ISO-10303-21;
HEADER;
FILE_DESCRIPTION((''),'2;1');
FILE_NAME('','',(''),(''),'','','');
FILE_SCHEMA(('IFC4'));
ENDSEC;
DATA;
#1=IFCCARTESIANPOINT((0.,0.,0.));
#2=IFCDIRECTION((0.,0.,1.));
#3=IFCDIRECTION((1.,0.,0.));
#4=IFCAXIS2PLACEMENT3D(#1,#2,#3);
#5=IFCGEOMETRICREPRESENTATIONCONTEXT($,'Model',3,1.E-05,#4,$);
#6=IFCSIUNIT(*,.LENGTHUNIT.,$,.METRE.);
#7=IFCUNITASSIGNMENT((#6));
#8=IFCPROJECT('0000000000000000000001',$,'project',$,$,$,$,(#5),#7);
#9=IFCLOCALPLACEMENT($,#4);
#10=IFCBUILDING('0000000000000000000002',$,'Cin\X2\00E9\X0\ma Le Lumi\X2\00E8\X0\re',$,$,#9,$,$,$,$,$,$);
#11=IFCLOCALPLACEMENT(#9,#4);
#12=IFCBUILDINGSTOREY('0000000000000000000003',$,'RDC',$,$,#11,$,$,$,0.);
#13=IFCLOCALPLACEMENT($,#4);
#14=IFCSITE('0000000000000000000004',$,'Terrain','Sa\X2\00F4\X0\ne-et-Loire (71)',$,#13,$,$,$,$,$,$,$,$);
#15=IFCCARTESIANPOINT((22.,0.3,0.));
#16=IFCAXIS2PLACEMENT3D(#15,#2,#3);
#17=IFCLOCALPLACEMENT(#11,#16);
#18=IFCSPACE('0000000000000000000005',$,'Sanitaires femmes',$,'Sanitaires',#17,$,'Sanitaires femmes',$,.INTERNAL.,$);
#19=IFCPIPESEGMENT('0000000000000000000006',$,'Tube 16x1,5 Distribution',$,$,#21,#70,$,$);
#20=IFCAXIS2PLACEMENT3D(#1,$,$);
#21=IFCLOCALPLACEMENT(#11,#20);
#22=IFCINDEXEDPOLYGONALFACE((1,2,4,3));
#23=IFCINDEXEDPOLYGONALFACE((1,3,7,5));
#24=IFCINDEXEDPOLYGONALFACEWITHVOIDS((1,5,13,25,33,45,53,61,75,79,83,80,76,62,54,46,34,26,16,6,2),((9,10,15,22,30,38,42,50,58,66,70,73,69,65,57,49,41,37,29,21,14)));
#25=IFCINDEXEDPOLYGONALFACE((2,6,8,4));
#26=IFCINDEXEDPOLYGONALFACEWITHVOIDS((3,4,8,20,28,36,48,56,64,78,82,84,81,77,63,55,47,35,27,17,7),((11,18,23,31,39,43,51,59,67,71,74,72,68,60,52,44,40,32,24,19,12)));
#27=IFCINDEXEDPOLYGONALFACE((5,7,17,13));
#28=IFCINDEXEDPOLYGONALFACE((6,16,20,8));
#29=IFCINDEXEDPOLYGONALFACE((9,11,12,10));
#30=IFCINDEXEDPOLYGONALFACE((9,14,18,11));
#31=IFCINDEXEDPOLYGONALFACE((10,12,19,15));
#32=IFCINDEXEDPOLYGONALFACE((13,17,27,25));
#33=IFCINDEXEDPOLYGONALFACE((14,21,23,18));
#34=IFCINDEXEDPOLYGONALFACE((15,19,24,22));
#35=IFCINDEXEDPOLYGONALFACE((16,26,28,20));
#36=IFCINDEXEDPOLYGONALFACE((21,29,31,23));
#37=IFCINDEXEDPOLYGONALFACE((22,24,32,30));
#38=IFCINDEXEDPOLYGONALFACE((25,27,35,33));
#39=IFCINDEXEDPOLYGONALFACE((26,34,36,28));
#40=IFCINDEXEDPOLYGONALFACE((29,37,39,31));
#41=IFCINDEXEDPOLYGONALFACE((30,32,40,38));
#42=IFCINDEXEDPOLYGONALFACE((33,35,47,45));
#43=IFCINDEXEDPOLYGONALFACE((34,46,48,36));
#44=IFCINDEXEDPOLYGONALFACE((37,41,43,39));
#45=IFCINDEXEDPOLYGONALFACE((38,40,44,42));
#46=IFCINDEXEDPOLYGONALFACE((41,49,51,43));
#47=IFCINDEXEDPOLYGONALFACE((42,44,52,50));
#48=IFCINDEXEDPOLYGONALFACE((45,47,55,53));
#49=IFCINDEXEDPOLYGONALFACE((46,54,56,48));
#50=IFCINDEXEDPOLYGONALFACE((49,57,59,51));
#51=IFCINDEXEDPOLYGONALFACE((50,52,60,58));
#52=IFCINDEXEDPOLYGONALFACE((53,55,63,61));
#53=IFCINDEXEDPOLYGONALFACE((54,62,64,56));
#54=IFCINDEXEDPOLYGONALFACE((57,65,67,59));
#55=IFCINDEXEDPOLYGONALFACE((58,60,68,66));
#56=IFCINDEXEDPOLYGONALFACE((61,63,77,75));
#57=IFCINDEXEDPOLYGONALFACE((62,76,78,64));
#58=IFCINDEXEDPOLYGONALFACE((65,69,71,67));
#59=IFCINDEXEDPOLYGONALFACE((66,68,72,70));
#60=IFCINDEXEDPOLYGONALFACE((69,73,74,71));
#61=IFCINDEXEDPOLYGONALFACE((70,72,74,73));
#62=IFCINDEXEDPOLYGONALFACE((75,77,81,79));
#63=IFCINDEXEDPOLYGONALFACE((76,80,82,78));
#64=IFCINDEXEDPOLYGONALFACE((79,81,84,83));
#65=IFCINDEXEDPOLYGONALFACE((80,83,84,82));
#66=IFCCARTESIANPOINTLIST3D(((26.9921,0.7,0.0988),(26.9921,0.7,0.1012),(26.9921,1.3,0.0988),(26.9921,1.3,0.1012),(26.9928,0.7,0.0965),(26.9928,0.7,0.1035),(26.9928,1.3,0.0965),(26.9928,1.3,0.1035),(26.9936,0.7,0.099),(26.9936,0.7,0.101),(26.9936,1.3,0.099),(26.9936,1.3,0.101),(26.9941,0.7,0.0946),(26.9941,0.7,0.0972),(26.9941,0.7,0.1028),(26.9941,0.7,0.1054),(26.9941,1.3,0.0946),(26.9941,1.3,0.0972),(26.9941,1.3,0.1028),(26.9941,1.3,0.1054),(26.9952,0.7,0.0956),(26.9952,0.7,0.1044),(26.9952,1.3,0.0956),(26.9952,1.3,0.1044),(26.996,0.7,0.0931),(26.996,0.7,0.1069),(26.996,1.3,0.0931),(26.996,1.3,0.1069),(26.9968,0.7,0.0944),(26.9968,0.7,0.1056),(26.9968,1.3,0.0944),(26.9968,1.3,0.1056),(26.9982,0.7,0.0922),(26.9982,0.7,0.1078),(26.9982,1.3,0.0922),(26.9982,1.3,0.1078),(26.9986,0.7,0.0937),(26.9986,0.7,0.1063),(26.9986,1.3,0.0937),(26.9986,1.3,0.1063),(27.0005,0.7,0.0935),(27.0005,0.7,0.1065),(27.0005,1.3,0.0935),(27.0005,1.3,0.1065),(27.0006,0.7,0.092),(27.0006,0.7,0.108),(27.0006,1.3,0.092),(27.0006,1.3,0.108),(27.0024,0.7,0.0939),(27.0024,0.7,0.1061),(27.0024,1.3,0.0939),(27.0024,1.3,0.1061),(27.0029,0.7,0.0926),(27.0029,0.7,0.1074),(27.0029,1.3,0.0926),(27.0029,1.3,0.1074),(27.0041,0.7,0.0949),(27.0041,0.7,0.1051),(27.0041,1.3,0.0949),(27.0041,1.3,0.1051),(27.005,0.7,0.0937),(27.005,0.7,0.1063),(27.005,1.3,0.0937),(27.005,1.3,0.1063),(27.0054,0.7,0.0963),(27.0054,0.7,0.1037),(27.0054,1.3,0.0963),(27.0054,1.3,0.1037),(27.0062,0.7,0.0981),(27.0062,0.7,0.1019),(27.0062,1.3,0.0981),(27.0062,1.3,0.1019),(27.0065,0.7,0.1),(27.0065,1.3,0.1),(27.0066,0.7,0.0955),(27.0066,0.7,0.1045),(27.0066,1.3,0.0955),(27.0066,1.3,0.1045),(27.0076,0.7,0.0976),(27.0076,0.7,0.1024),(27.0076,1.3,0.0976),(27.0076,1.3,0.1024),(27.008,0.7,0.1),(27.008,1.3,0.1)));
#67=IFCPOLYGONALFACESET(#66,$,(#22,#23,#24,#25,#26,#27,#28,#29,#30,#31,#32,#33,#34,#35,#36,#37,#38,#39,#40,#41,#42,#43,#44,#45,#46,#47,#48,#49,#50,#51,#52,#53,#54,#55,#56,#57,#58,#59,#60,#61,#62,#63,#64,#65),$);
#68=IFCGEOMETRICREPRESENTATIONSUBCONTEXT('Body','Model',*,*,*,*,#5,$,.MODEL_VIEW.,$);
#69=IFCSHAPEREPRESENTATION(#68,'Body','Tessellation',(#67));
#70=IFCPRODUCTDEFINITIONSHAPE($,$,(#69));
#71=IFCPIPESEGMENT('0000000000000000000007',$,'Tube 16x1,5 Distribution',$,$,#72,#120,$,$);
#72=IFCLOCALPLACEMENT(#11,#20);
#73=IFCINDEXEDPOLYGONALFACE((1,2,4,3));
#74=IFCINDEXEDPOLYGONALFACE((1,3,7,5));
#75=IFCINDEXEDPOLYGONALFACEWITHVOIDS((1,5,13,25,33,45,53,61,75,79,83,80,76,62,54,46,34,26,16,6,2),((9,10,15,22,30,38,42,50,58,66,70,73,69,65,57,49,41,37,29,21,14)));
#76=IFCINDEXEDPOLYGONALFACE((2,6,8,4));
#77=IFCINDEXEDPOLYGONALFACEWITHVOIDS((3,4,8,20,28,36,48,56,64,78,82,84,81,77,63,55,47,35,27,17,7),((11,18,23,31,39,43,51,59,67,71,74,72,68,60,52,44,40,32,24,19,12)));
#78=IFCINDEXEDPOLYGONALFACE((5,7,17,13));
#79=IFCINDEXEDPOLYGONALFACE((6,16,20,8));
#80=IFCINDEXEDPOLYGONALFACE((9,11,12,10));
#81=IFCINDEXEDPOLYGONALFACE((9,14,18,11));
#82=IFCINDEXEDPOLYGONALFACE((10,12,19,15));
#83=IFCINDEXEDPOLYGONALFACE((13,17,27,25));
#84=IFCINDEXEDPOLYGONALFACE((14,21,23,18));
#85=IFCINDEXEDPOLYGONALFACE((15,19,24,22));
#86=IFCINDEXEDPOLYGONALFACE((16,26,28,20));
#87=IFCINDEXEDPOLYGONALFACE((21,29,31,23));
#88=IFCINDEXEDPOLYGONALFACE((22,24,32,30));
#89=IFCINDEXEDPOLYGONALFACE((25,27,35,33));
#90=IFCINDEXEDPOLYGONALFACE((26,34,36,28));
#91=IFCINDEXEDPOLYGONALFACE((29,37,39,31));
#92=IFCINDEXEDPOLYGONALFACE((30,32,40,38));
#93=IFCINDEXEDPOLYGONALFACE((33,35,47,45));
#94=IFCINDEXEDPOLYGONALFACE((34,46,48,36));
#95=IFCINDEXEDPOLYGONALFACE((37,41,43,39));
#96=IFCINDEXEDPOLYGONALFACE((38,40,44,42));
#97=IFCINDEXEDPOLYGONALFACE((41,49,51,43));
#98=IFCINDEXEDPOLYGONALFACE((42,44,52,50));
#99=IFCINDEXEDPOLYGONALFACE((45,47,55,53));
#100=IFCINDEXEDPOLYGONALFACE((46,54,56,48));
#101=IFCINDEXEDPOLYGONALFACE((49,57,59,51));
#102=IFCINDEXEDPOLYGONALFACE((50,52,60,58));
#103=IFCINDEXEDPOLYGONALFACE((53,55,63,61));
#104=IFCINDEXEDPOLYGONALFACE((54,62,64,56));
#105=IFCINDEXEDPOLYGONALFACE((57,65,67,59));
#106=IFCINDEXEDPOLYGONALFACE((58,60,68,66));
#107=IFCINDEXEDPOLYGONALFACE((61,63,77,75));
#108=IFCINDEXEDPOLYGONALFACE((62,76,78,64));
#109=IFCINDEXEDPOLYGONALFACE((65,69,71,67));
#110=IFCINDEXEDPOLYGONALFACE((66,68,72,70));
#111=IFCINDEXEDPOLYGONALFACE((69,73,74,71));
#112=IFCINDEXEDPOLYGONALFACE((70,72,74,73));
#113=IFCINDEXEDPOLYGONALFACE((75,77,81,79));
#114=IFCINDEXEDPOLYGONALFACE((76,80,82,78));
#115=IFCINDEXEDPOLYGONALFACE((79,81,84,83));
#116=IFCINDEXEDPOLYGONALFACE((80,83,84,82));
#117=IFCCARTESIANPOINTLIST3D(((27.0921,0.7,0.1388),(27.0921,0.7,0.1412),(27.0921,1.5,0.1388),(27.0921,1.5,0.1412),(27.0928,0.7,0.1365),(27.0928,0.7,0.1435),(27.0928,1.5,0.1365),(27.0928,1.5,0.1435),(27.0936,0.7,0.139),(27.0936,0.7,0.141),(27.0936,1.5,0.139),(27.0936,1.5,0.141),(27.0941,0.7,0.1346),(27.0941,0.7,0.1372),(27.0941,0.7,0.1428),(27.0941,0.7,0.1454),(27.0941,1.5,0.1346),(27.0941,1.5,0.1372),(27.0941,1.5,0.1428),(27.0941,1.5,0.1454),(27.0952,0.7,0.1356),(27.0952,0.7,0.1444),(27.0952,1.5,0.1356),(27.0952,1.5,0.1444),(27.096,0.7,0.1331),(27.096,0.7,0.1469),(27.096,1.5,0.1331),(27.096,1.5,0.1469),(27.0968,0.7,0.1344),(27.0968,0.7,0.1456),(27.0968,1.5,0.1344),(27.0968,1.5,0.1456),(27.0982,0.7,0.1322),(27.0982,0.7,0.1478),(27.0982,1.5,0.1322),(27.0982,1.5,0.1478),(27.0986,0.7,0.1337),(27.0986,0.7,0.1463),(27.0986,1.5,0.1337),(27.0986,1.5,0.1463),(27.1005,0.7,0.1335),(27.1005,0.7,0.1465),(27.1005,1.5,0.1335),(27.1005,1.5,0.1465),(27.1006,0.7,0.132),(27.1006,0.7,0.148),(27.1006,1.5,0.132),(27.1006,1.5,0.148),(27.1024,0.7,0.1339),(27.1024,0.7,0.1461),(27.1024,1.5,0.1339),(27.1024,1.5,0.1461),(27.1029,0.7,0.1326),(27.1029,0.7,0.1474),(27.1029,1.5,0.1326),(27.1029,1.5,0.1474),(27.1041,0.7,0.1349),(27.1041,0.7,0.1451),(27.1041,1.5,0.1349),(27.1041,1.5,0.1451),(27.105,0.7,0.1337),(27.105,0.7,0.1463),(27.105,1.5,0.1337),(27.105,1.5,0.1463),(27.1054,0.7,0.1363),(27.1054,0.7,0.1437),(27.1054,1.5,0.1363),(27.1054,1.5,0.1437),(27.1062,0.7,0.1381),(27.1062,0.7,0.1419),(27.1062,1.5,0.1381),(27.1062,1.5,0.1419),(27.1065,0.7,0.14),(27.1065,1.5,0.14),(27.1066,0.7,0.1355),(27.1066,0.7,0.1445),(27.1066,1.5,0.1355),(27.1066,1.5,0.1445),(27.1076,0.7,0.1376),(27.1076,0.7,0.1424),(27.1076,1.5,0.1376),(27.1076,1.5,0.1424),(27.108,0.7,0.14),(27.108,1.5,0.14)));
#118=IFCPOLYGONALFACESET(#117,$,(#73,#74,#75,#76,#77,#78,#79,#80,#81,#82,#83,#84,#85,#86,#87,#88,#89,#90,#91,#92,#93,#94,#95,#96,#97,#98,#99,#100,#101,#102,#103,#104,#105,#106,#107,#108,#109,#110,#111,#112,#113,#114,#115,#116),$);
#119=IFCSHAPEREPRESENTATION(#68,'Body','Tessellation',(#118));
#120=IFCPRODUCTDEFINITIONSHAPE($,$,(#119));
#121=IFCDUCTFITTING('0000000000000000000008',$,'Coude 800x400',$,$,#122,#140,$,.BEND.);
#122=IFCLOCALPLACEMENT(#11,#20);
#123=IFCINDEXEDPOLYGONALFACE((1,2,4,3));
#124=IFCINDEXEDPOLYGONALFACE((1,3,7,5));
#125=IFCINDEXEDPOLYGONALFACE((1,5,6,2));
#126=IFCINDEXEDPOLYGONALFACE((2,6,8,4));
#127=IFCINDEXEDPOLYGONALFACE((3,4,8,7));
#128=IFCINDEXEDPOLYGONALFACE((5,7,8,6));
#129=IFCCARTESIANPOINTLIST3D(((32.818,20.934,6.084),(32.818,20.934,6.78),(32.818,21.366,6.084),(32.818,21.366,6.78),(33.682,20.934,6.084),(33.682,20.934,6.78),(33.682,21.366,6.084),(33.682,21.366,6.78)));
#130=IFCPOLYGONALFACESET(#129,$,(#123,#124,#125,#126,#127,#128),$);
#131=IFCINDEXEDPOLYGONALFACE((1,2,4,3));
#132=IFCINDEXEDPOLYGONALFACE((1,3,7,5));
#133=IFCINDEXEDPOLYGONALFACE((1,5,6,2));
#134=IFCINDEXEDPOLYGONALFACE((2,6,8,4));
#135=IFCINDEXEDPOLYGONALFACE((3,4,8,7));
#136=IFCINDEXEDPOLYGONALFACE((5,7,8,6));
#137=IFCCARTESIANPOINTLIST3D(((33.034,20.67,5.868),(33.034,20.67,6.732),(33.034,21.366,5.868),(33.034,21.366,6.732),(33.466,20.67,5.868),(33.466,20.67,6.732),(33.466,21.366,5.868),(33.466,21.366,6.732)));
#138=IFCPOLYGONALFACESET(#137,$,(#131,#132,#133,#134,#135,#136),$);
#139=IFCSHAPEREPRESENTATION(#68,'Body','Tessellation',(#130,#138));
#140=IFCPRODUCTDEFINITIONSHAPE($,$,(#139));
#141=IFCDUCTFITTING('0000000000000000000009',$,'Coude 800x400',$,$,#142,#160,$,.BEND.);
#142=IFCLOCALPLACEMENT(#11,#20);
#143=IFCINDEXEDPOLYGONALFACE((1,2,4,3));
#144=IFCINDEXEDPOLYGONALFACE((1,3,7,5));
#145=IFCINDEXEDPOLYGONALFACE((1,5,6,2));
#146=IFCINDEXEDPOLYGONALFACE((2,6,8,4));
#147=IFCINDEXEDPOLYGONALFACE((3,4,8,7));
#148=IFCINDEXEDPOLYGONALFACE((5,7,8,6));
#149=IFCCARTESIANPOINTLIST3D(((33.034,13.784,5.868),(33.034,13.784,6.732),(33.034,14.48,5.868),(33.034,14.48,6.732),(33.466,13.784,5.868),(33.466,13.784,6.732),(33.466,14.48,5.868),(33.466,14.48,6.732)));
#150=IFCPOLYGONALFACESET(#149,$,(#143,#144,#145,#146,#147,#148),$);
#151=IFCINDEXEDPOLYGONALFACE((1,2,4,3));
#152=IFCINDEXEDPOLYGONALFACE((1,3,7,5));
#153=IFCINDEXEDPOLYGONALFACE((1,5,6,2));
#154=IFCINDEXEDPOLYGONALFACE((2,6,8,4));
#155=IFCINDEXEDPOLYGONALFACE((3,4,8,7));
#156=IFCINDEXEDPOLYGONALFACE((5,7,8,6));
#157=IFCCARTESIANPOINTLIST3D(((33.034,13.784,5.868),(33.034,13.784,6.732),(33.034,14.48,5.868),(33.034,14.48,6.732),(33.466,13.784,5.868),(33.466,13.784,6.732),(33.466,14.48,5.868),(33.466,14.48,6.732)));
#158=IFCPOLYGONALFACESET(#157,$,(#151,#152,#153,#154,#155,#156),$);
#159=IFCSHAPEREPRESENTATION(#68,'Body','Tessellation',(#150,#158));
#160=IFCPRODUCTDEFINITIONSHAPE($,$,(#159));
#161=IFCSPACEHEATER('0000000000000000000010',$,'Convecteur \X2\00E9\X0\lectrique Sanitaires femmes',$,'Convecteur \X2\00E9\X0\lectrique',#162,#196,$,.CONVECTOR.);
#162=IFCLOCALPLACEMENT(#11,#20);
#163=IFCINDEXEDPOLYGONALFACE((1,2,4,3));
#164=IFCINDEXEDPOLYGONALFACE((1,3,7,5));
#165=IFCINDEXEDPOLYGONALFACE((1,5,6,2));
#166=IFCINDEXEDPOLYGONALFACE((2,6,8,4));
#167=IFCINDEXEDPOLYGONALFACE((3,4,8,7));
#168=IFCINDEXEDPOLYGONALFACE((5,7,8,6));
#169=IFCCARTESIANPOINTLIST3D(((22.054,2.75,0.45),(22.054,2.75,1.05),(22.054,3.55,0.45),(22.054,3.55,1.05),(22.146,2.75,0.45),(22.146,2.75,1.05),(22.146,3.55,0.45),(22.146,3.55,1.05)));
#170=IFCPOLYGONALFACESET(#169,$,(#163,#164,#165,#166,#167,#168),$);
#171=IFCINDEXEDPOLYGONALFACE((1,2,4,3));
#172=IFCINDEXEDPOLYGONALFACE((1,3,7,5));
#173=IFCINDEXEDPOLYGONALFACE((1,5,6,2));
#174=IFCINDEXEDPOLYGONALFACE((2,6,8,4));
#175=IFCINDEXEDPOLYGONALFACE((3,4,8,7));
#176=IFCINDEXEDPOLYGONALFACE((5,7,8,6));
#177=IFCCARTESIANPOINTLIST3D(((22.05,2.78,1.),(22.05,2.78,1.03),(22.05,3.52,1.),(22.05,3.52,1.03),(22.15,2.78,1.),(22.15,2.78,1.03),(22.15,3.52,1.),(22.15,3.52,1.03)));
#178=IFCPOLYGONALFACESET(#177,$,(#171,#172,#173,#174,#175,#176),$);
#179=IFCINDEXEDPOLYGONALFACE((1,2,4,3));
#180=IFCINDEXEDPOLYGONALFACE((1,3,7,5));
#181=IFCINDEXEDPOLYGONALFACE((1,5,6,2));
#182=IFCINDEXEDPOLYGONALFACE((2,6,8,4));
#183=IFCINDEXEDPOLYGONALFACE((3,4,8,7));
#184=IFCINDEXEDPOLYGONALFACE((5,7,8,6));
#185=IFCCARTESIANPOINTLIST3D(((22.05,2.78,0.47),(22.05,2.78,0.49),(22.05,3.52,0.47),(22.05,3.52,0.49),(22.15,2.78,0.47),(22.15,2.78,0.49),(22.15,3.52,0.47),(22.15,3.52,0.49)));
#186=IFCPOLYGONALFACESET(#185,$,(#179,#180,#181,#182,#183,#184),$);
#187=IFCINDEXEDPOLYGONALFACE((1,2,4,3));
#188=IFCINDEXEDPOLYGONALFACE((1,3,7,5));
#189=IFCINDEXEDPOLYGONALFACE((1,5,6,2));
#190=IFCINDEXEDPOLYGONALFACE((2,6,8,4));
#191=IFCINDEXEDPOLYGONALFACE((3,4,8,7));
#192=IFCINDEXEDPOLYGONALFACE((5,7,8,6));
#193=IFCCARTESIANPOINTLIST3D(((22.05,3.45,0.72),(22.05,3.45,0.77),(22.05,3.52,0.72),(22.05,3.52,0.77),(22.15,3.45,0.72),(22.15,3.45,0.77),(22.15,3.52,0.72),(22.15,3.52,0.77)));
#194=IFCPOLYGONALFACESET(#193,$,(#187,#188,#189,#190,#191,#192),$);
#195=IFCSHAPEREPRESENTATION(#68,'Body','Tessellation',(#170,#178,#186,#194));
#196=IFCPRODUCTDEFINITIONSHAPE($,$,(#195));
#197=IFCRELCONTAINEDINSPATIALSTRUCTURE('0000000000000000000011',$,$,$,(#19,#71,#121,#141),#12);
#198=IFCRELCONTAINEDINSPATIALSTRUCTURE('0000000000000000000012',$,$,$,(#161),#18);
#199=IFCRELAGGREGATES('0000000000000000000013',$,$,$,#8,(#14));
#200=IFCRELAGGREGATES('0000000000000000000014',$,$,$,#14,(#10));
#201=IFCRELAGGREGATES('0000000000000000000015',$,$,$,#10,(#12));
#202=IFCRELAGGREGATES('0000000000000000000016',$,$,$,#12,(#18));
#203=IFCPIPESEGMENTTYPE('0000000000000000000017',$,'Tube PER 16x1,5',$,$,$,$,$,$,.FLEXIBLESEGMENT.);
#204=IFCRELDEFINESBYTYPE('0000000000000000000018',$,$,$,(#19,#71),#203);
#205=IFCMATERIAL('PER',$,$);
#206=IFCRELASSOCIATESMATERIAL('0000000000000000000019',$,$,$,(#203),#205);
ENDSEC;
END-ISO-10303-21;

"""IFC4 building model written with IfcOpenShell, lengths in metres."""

from ifc_helpers import new_model, si_unit, frame, frame_2d, origin_with_axes, origin_2d, place, context, subcontext, project, spatial, rectangle, hollow_circle, extrude, material, type_object, element, save


model = new_model("IFC4")

# Units and contexts
model_context = context("Model", 3, precision=1e-05, world=origin_with_axes())
body_context = subcontext(model_context, "Body", "Model", "MODEL_VIEW")
ifc_project = project(units=[si_unit("LENGTHUNIT", "METRE")], contexts=[model_context])

# Site, building, storey
site_placement = place(None, origin_with_axes())
site = spatial("IfcSite", under=ifc_project, at=site_placement, Name="Terrain", Description="Saône-et-Loire (71)")
building_placement = place(None, origin_with_axes())
building = spatial("IfcBuilding", under=site, at=building_placement, Name="Cinéma Le Lumière")
storey_placement = place(building_placement, origin_with_axes())
storey = spatial("IfcBuildingStorey", under=building, at=storey_placement, Name="RDC", Elevation=0.0)

# Pipe segments
ifc_material_1 = material(Name="PER")
pipe_segment_type = type_object("IfcPipeSegmentType", Name="Tube PER 16x1,5", PredefinedType="FLEXIBLESEGMENT", material=ifc_material_1)
pipe_segment_1_placement = place(storey_placement, frame((27.0, 1.3, 0.1), z_axis=(0.0, -1.0, 0.0), x_axis=(1.0, 0.0, 0.0)))
element("IfcPipeSegment", 1, at=pipe_segment_1_placement, inside=storey, type_object=pipe_segment_type, Name="Tube 16x1,5 Distribution", context=body_context, shape_type="SweptSolid", body=[
    extrude(hollow_circle(Radius=0.008, WallThickness=0.0015), origin_with_axes(), (0.0, 0.0, 1.0), 0.6),
])
pipe_segment_2_placement = place(storey_placement, frame((27.1, 1.5, 0.14), z_axis=(0.0, -1.0, 0.0), x_axis=(1.0, 0.0, 0.0)))
element("IfcPipeSegment", 2, at=pipe_segment_2_placement, inside=storey, type_object=pipe_segment_type, Name="Tube 16x1,5 Distribution", context=body_context, shape_type="SweptSolid", body=[
    extrude(hollow_circle(Radius=0.008, WallThickness=0.0015), origin_with_axes(), (0.0, 0.0, 1.0), 0.8),
])

# Duct fittings
duct_fitting_1_placement = place(storey_placement, frame((33.25, 21.15, 6.3), z_axis=(0.0, 0.0, 1.0), x_axis=(1.0, 0.0, 0.0)))
element("IfcDuctFitting", 3, at=duct_fitting_1_placement, inside=storey, Name="Coude 800x400", PredefinedType="BEND", context=body_context, shape_type="SweptSolid", body=[
    extrude(rectangle(XDim=0.864, YDim=0.432, at=origin_2d()), frame((0.0, 0.0, -0.216), z_axis=(0.0, 0.0, 1.0), x_axis=(1.0, 0.0, 0.0)), (0.0, 0.0, 1.0), 0.696),
    extrude(rectangle(XDim=0.864, YDim=0.432, at=origin_2d()), frame((0.0, 0.216, 0.0), z_axis=(0.0, -1.0, 0.0), x_axis=(0.0, 0.0, 1.0)), (0.0, 0.0, 1.0), 0.696),
])
duct_fitting_2_placement = place(storey_placement, frame((33.25, 14.0, 6.3), z_axis=(0.0, 0.0, 1.0), x_axis=(1.0, 0.0, 0.0)))
element("IfcDuctFitting", 4, at=duct_fitting_2_placement, inside=storey, Name="Coude 800x400", PredefinedType="BEND", context=body_context, shape_type="SweptSolid", body=[
    extrude(rectangle(XDim=0.864, YDim=0.432, at=origin_2d()), frame((0.0, -0.216, 0.0), z_axis=(0.0, 1.0, 0.0), x_axis=(0.0, 0.0, 1.0)), (0.0, 0.0, 1.0), 0.696),
    extrude(rectangle(XDim=0.864, YDim=0.432, at=origin_2d()), frame((0.0, -0.216, 0.0), z_axis=(0.0, 1.0, 0.0), x_axis=(0.0, 0.0, 1.0)), (0.0, 0.0, 1.0), 0.696),
])

# Shared definitions
space_1_placement = place(storey_placement, frame((22.0, 0.3, 0.0), z_axis=(0.0, 0.0, 1.0), x_axis=(1.0, 0.0, 0.0)))
space_1 = spatial("IfcSpace", under=storey, at=space_1_placement, Name="Sanitaires femmes", ObjectType="Sanitaires", LongName="Sanitaires femmes", PredefinedType="INTERNAL")

# Space heater
space_heater_placement = place(space_1_placement, frame((0.05, 2.45, 0.45), z_axis=(0.0, 0.0, 1.0), x_axis=(1.0, 0.0, 0.0)))
element("IfcSpaceHeater", 5, at=space_heater_placement, inside=space_1, Name="Convecteur électrique Sanitaires femmes", ObjectType="Convecteur électrique", PredefinedType="CONVECTOR", context=body_context, shape_type="SweptSolid", body=[
    extrude(rectangle(XDim=0.092, YDim=0.8, at=frame_2d((0.046, 0.4))), frame((0.004, 0.0, 0.0), z_axis=(0.0, 0.0, 1.0), x_axis=(1.0, 0.0, 0.0)), (0.0, 0.0, 1.0), 0.6),
    extrude(rectangle(XDim=0.1, YDim=0.74, at=frame_2d((0.05, 0.37))), frame((0.0, 0.03, 0.55), z_axis=(0.0, 0.0, 1.0), x_axis=(1.0, 0.0, 0.0)), (0.0, 0.0, 1.0), 0.03),
    extrude(rectangle(XDim=0.1, YDim=0.74, at=frame_2d((0.05, 0.37))), frame((0.0, 0.03, 0.02), z_axis=(0.0, 0.0, 1.0), x_axis=(1.0, 0.0, 0.0)), (0.0, 0.0, 1.0), 0.02),
    extrude(rectangle(XDim=0.1, YDim=0.07, at=frame_2d((0.05, 0.035))), frame((0.0, 0.7, 0.27), z_axis=(0.0, 0.0, 1.0), x_axis=(1.0, 0.0, 0.0)), (0.0, 0.0, 1.0), 0.05),
])

save(model, "model.ifc")
